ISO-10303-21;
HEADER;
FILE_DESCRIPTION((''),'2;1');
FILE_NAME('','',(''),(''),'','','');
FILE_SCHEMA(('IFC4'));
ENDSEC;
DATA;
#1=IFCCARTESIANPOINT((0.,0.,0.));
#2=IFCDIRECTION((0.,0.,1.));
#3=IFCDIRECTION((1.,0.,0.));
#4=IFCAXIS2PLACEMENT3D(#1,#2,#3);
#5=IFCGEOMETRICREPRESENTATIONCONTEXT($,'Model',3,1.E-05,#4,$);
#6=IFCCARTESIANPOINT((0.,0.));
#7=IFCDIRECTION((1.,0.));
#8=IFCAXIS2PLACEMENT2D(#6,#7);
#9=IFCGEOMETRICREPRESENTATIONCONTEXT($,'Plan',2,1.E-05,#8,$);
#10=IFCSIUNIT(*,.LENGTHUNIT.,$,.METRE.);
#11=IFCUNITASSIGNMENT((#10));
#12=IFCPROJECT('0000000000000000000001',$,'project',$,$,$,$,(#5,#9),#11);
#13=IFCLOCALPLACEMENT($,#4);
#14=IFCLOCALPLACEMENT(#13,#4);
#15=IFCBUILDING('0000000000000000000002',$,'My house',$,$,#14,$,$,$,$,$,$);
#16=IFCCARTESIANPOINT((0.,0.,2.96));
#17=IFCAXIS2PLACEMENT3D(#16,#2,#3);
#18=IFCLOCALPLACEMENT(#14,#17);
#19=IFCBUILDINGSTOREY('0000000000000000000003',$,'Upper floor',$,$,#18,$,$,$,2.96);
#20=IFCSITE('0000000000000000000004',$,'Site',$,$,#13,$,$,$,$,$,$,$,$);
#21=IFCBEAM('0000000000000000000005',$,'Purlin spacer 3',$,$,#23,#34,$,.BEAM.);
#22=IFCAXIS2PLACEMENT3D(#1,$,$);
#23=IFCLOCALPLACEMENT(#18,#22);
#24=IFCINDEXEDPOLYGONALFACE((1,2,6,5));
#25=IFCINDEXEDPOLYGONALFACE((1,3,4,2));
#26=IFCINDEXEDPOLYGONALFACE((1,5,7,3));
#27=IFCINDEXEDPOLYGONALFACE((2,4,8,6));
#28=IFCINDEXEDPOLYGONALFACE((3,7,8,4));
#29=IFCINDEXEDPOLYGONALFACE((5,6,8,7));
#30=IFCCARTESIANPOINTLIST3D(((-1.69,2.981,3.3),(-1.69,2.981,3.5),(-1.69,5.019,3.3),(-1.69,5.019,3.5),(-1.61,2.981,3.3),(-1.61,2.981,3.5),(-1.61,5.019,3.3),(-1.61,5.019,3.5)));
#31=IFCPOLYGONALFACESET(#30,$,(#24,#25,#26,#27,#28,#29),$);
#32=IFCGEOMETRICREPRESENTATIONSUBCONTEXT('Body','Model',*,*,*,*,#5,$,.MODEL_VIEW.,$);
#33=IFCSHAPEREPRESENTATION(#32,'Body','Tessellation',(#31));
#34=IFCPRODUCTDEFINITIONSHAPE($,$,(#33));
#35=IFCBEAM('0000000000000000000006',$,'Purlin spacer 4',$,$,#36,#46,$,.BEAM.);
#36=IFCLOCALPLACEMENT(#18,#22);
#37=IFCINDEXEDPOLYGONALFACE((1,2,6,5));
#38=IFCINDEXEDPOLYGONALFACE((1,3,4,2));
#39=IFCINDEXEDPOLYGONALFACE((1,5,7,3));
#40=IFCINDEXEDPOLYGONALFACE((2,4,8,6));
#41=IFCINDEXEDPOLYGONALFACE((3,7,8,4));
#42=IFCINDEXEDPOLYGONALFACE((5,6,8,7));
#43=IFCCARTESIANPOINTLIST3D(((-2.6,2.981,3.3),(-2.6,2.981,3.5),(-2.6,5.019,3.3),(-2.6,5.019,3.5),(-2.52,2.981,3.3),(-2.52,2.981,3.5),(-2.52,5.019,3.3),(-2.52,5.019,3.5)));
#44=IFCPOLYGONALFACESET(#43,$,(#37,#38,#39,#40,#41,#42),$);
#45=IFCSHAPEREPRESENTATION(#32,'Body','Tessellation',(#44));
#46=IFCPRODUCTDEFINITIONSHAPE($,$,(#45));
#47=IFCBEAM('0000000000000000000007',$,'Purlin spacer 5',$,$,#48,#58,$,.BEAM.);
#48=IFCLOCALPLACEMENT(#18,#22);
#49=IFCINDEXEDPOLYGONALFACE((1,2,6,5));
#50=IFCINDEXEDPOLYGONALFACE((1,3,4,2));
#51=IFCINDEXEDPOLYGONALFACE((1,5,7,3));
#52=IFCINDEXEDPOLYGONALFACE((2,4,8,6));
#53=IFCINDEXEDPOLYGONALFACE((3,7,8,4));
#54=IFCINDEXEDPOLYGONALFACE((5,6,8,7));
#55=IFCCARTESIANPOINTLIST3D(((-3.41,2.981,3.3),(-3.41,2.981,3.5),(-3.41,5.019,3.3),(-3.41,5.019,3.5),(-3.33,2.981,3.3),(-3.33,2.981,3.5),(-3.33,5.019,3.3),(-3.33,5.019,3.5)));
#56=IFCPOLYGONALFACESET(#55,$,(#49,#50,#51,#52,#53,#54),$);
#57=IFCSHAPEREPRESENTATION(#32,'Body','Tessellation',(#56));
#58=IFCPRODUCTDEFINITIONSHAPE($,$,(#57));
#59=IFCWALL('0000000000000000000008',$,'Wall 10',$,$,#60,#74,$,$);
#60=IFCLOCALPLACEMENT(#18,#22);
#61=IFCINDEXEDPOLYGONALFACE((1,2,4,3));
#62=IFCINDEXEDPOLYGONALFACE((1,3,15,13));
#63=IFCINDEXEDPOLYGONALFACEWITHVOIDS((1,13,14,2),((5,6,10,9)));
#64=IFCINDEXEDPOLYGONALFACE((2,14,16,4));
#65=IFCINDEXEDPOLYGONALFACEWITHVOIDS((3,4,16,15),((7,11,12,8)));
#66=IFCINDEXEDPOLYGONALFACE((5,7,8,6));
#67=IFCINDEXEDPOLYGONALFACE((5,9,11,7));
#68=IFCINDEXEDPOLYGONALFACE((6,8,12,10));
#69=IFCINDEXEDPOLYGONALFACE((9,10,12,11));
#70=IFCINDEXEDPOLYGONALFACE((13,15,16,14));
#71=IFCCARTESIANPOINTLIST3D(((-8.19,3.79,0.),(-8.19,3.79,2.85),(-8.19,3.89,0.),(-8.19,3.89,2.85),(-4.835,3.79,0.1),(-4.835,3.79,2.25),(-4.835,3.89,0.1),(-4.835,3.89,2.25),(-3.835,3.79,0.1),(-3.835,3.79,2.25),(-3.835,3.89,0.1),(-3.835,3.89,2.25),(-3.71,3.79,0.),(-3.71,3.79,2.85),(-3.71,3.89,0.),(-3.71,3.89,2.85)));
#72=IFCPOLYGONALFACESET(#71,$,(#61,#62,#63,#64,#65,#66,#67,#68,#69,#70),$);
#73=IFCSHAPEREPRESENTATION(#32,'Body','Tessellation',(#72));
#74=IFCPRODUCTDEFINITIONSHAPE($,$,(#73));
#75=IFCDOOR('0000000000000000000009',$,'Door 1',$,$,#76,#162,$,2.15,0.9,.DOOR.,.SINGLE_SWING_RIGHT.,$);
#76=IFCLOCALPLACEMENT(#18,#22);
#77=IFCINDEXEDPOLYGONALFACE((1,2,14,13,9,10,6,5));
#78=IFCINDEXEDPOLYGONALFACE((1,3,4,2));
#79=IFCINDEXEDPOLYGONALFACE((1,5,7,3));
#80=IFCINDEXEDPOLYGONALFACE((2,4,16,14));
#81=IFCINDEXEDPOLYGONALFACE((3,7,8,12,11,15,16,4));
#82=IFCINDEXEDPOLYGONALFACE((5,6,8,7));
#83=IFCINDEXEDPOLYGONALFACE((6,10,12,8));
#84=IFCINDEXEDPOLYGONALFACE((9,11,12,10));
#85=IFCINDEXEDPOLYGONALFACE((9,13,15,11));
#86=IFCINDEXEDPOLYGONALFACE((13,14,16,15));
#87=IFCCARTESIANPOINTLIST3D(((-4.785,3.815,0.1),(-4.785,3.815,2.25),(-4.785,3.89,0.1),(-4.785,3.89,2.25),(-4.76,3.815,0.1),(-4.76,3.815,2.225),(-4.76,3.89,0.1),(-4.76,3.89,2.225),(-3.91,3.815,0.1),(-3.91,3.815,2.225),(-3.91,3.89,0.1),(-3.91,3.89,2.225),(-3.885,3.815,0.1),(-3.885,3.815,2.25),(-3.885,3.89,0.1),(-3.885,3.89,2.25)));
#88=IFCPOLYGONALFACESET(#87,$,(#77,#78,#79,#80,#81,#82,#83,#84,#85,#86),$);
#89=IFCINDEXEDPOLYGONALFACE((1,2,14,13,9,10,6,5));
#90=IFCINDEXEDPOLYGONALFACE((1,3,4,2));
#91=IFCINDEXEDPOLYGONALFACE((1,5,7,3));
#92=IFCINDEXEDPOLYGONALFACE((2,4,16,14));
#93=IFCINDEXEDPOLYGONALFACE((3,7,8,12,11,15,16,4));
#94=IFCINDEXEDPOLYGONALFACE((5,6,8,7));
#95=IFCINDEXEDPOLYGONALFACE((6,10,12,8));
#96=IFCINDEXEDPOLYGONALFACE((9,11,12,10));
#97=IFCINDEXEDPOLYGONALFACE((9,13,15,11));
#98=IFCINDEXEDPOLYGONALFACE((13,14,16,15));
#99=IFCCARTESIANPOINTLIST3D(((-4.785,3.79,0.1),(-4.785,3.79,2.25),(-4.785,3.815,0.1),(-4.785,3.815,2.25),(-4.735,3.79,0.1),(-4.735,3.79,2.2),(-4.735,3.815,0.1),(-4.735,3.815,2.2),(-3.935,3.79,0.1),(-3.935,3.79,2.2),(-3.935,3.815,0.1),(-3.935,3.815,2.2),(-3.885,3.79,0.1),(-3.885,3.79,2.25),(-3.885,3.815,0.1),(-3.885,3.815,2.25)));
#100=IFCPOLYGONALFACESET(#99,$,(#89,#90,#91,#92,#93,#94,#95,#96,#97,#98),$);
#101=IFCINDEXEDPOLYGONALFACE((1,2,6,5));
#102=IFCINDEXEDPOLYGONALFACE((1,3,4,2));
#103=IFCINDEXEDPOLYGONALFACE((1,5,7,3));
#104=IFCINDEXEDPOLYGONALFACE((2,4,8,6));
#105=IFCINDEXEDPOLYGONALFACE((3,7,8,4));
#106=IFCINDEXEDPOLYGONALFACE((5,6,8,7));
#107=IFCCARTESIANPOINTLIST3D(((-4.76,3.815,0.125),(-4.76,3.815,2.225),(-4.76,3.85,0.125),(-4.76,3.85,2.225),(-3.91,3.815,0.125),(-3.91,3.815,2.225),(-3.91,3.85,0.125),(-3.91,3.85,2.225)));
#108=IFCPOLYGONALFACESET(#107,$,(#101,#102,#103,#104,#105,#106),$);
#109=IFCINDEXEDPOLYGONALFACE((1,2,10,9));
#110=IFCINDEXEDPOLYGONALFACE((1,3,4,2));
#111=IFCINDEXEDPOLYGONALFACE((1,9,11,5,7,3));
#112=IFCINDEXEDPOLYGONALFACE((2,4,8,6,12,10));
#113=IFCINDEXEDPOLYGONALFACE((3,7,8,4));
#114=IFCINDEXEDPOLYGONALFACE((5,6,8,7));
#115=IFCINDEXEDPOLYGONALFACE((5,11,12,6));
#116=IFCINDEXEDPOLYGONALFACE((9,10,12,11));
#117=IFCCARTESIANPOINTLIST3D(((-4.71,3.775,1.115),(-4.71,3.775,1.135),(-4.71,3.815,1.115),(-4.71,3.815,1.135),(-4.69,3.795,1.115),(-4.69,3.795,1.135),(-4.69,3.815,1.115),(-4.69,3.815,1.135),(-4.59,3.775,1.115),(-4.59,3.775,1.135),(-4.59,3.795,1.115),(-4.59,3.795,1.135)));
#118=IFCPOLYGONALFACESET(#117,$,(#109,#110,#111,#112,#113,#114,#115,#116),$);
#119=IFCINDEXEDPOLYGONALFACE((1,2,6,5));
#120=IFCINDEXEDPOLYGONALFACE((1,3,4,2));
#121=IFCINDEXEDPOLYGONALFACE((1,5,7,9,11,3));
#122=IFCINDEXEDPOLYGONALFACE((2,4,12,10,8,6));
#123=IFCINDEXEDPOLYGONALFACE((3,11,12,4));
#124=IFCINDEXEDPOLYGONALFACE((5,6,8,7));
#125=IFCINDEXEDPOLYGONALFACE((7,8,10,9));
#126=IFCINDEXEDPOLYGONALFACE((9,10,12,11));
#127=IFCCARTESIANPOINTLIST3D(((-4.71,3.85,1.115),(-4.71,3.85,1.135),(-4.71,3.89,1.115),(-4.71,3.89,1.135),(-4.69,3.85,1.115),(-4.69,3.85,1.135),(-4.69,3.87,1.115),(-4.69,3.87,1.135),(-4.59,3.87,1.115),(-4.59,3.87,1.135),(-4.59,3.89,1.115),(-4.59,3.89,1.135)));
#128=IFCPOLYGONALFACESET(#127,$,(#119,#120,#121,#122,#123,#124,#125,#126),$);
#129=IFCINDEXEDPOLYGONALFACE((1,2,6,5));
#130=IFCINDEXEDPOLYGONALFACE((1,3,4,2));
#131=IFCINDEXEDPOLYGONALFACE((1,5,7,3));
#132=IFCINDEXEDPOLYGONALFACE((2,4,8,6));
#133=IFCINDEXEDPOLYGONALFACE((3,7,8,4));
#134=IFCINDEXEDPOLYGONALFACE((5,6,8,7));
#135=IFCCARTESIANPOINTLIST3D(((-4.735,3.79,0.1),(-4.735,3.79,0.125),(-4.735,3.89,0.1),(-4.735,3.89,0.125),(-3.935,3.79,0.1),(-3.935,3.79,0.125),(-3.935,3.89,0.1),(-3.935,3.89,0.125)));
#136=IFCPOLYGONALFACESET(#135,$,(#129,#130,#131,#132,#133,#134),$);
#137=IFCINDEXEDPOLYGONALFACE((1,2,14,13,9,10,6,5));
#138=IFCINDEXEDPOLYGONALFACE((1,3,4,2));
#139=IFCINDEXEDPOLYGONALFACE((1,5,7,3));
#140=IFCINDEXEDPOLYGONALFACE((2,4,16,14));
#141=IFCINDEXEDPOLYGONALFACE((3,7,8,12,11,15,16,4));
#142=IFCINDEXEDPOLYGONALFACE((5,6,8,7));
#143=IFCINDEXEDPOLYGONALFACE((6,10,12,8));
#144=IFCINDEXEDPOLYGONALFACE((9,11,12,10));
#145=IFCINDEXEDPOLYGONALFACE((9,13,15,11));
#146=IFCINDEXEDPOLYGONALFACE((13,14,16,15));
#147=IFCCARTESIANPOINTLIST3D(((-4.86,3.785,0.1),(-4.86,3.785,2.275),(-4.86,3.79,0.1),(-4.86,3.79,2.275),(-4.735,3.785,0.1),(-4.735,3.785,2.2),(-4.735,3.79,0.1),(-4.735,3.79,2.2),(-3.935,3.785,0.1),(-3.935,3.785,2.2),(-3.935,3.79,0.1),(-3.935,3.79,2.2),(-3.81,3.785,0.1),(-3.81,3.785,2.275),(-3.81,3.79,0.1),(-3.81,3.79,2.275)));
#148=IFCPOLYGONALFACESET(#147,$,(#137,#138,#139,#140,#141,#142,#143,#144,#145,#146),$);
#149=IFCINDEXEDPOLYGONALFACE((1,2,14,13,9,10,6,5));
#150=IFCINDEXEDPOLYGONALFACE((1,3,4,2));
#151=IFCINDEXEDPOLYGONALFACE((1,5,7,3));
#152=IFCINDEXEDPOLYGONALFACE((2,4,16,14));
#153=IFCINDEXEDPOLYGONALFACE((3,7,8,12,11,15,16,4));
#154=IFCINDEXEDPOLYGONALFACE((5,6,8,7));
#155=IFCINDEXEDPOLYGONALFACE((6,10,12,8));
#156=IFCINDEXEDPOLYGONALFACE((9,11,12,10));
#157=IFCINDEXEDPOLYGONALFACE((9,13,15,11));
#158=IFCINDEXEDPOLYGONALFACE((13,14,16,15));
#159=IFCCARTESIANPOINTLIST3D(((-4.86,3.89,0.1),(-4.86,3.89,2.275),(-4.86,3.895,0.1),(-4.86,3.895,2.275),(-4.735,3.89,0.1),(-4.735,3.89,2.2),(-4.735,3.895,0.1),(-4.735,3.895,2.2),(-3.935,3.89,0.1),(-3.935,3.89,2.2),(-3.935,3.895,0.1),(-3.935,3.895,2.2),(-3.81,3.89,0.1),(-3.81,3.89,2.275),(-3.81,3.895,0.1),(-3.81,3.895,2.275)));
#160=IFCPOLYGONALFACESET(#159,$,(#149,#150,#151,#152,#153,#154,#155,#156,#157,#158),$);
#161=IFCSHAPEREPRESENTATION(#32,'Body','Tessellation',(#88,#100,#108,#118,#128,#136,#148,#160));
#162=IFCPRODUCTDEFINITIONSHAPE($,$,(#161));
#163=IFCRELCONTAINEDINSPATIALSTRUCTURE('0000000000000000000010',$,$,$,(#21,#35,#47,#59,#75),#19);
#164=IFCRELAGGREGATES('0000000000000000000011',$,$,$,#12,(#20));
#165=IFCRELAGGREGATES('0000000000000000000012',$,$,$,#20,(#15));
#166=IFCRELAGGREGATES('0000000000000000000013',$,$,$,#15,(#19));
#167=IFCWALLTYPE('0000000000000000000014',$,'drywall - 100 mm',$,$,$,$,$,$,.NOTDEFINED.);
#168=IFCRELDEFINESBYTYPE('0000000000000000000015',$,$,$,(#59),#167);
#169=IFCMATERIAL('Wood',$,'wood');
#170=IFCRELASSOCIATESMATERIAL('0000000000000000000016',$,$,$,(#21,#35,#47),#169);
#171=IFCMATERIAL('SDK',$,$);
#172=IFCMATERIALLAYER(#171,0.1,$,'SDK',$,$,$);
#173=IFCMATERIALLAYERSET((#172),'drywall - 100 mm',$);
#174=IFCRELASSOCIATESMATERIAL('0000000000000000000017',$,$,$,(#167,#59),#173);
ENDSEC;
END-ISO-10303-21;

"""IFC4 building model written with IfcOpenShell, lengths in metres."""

from ifc_helpers import new_model, entity, si_unit, frame, origin_with_axes, origin_2d_with_axis, place, context, subcontext, project, spatial, line, indexed_curve, rectangle, outline, extrude, shape, source, transform, mapped, material, layer, layer_set, layer_usage, type_object, element, fill, save


model = new_model("IFC4")

# Units and contexts
model_context = context("Model", 3, precision=1e-05, world=origin_with_axes())
plan_context = context("Plan", 2, precision=1e-05, world=origin_2d_with_axis())
body_context_1 = subcontext(model_context, "Body", "Model", "MODEL_VIEW")
body_context_2 = subcontext(plan_context, "Body", "Plan", "PLAN_VIEW")
ifc_project = project(units=[si_unit("LENGTHUNIT", "METRE")], contexts=[model_context, plan_context])

# Site, building, storey
site_placement = place(None, origin_with_axes())
site = spatial("IfcSite", under=ifc_project, at=site_placement, Name="Site")
building_placement = place(site_placement, origin_with_axes())
building = spatial("IfcBuilding", under=site, at=building_placement, Name="My house")
storey_placement = place(building_placement, frame((0.0, 0.0, 2.96), z_axis=(0.0, 0.0, 1.0), x_axis=(1.0, 0.0, 0.0)))
storey = spatial("IfcBuildingStorey", under=building, at=storey_placement, Name="Upper floor", Elevation=2.96)

# Shared definitions
ifc_material_1 = material(Name="Wood", Category="wood")

# Beams
shared_shape_1 = source(origin_with_axes(), body_context_1, "Body", "SweptSolid", [
    extrude(rectangle(XDim=0.08, YDim=0.2), frame((0.0, 0.0, 0.0), z_axis=(1.0, 0.0, 0.0), x_axis=(0.0, 1.0, 0.0)), (0.0, 0.0, 1.0), 2.038),
])
beam_1_placement = place(storey_placement, frame((-1.65, 2.981, 3.4), z_axis=(0.0, 0.0, 1.0), x_axis=(0.0, -1.0, 0.0)))
element("IfcBeam", 1, at=beam_1_placement, inside=storey, material=ifc_material_1, Name="Purlin spacer 3", PredefinedType="BEAM", context=body_context_1, shape_type="MappedRepresentation", body=[
    mapped(shared_shape_1, transform((0.0, 0.0, 0.0), x_axis=(-1.0, 0.0, 0.0), y_axis=(0.0, 1.0, 0.0), z_axis=(0.0, 0.0, 1.0), scale=1.0)),
])
shared_shape_2 = source(origin_with_axes(), body_context_1, "Body", "SweptSolid", [
    extrude(rectangle(XDim=0.08, YDim=0.2), frame((0.0, 0.0, 0.0), z_axis=(1.0, 0.0, 0.0), x_axis=(0.0, 1.0, 0.0)), (0.0, 0.0, 1.0), 2.038),
])
beam_2_placement = place(storey_placement, frame((-2.56, 2.981, 3.4), z_axis=(0.0, 0.0, 1.0), x_axis=(0.0, -1.0, 0.0)))
element("IfcBeam", 2, at=beam_2_placement, inside=storey, material=ifc_material_1, Name="Purlin spacer 4", PredefinedType="BEAM", context=body_context_1, shape_type="MappedRepresentation", body=[
    mapped(shared_shape_2, transform((0.0, 0.0, 0.0), x_axis=(-1.0, 0.0, 0.0), y_axis=(0.0, 1.0, 0.0), z_axis=(0.0, 0.0, 1.0), scale=1.0)),
])
shared_shape_3 = source(origin_with_axes(), body_context_1, "Body", "SweptSolid", [
    extrude(rectangle(XDim=0.08, YDim=0.2), frame((0.0, 0.0, 0.0), z_axis=(1.0, 0.0, 0.0), x_axis=(0.0, 1.0, 0.0)), (0.0, 0.0, 1.0), 2.038),
])
beam_3_placement = place(storey_placement, frame((-3.37, 2.981, 3.4), z_axis=(0.0, 0.0, 1.0), x_axis=(0.0, -1.0, 0.0)))
element("IfcBeam", 3, at=beam_3_placement, inside=storey, material=ifc_material_1, Name="Purlin spacer 5", PredefinedType="BEAM", context=body_context_1, shape_type="MappedRepresentation", body=[
    mapped(shared_shape_3, transform((0.0, 0.0, 0.0), x_axis=(-1.0, 0.0, 0.0), y_axis=(0.0, 1.0, 0.0), z_axis=(0.0, 0.0, 1.0), scale=1.0)),
])

# Wall, opening, door
ifc_material_2 = material(Name="SDK")
ifc_layer_1 = layer(ifc_material_2, 0.1, Name="SDK")
ifc_layer_set_1 = layer_set([ifc_layer_1], Name="drywall - 100 mm")
ifc_layer_usage_1 = layer_usage(ifc_layer_set_1, "AXIS2", "NEGATIVE", 0.1)
wall_type_1 = type_object("IfcWallType", Name="drywall - 100 mm", PredefinedType="NOTDEFINED", material=ifc_layer_set_1)
shared_shape_4 = source(origin_with_axes(), body_context_1, "Body", "SweptSolid", [
    extrude(outline(indexed_curve([(0.0, 0.0), (0.0, 0.1), (4.48, 0.1), (4.48, 0.0), (0.0, 0.0)], self_intersect=False)), origin_with_axes(), (0.0, 0.0, 1.0), 2.85),
])
wall_1_placement = place(storey_placement, frame((-3.71, 3.79, 0.0), z_axis=(0.0, 0.0, 1.0), x_axis=(1.0, 0.0, 0.0)))
wall_1 = element("IfcWall", 4, at=wall_1_placement, inside=storey, type_object=wall_type_1, material=ifc_layer_usage_1, Name="Wall 10", context=body_context_1, shape_type="MappedRepresentation", body=[
    mapped(shared_shape_4, transform((0.0, 0.0, 0.0), x_axis=(-1.0, 0.0, 0.0), y_axis=(0.0, 1.0, 0.0), z_axis=(0.0, 0.0, 1.0), scale=1.0)),
])
shared_shape_5 = source(origin_with_axes(), body_context_1, "Body", "SweptSolid", [
    extrude(outline(indexed_curve([(0.0, 0.0), (0.0, 0.2), (1.0, 0.2), (1.0, 0.0), (0.0, 0.0)], self_intersect=False)), frame((0.0, -0.05, 0.0), z_axis=(0.0, 0.0, 1.0), x_axis=(1.0, 0.0, 0.0)), (0.0, 0.0, 1.0), 2.15),
])
opening_placement = place(wall_1_placement, frame((-0.125, 0.0, 0.1), z_axis=(0.0, 0.0, 1.0), x_axis=(1.0, 0.0, 0.0)))
opening = element("IfcOpeningElement", 5, at=opening_placement, cuts=wall_1, PredefinedType="OPENING", context=body_context_1, shape_type="MappedRepresentation", body=[
    mapped(shared_shape_5, transform((0.0, 0.0, 0.0), x_axis=(-1.0, 0.0, 0.0), y_axis=(0.0, 1.0, 0.0), z_axis=(0.0, 0.0, 1.0), scale=1.0)),
])
shared_indexed_poly_curve = entity("IfcIndexedPolyCurve", entity("IfcCartesianPointList2D", [[-0.075, 0.0], [-0.075, 2.175], [0.975, 2.175], [0.975, 0.0], [0.85, 0.0], [0.85, 2.1], [0.05, 2.1], [0.05, 0.0]]), [entity("IfcLineIndex", [1, 2, 3, 4, 5, 6, 7, 8, 1])])
shared_shape_6 = source(origin_with_axes(), body_context_1, "Body", "SweptSolid", [
    extrude(outline(indexed_curve([(0.0, 0.0), (0.0, 2.15), (0.9, 2.15), (0.9, 0.0), (0.875, 0.0), (0.875, 2.125), (0.025, 2.125), (0.025, 0.0)], segments=[line(1, 2, 3, 4, 5, 6, 7, 8, 1)])), frame((0.0, 0.025, 0.0), z_axis=(0.0, -1.0, 0.0), x_axis=(1.0, 0.0, 0.0)), (0.0, 0.0, -1.0), 0.075),
    extrude(outline(indexed_curve([(0.0, 0.0), (0.0, 2.15), (0.9, 2.15), (0.9, 0.0), (0.85, 0.0), (0.85, 2.1), (0.05, 2.1), (0.05, 0.0)], segments=[line(1, 2, 3, 4, 5, 6, 7, 8, 1)])), frame((0.0, 0.0, 0.0), z_axis=(0.0, -1.0, 0.0), x_axis=(1.0, 0.0, 0.0)), (0.0, 0.0, -1.0), 0.025),
    extrude(outline(indexed_curve([(0.0, 0.0), (0.85, 0.0), (0.85, 0.035), (0.0, 0.035)], segments=[line(1, 2, 3, 4, 1)])), frame((0.025, 0.025, 0.025), z_axis=(0.0, 0.0, 1.0), x_axis=(1.0, 0.0, 0.0)), (0.0, 0.0, 1.0), 2.1),
    extrude(outline(indexed_curve([(0.0, 0.0), (0.0, -0.04), (-0.12, -0.04), (-0.12, -0.02), (-0.02, -0.02), (-0.02, 0.0)], segments=[line(1, 2, 3, 4, 5, 6, 1)])), frame((0.825, 0.025, 1.015), z_axis=(0.0, 0.0, 1.0), x_axis=(1.0, 0.0, 0.0)), (0.0, 0.0, 1.0), 0.02),
    extrude(outline(indexed_curve([(0.0, 0.0), (0.0, 0.04), (-0.12, 0.04), (-0.12, 0.02), (-0.02, 0.02), (-0.02, 0.0)], segments=[line(1, 2, 3, 4, 5, 6, 1)])), frame((0.825, 0.06, 1.015), z_axis=(0.0, 0.0, 1.0), x_axis=(1.0, 0.0, 0.0)), (0.0, 0.0, 1.0), 0.02),
    extrude(outline(indexed_curve([(0.0, 0.0), (0.8, 0.0), (0.8, 0.1), (0.0, 0.1)], segments=[line(1, 2, 3, 4, 1)])), frame((0.05, 0.0, 0.0), z_axis=(0.0, 0.0, 1.0), x_axis=(1.0, 0.0, 0.0)), (0.0, 0.0, 1.0), 0.025),
    entity("IfcExtrudedAreaSolid", entity("IfcArbitraryClosedProfileDef", "AREA", None, shared_indexed_poly_curve), entity("IfcAxis2Placement3D", entity("IfcCartesianPoint", [0.0, -0.005, 0.0]), entity("IfcDirection", [0.0, -1.0, 0.0]), entity("IfcDirection", [1.0, 0.0, 0.0])), entity("IfcDirection", [0.0, 0.0, -1.0]), 0.005),
    entity("IfcExtrudedAreaSolid", entity("IfcArbitraryClosedProfileDef", "AREA", None, shared_indexed_poly_curve), entity("IfcAxis2Placement3D", entity("IfcCartesianPoint", [0.0, 0.1, 0.0]), entity("IfcDirection", [0.0, -1.0, 0.0]), entity("IfcDirection", [1.0, 0.0, 0.0])), entity("IfcDirection", [0.0, 0.0, -1.0]), 0.005),
])
shared_shape_7 = source(origin_with_axes(), body_context_2, "Body", "Curve2D", [
    entity("IfcIndexedPolyCurve", entity("IfcCartesianPointList2D", [[0.0, 0.0], [0.0, 0.1], [0.025, 0.1], [0.025, 0.025], [0.05, 0.025], [0.05, 0.0]]), [entity("IfcLineIndex", [1, 2, 3, 4, 5, 6, 1])]),
    entity("IfcIndexedPolyCurve", entity("IfcCartesianPointList2D", [[0.9, 0.0], [0.9, 0.1], [0.875, 0.1], [0.875, 0.025], [0.85, 0.025], [0.85, 0.0]]), [entity("IfcLineIndex", [1, 2, 3, 4, 5, 6, 1])]),
    entity("IfcTrimmedCurve", entity("IfcEllipse", entity("IfcAxis2Placement2D", entity("IfcCartesianPoint", [0.06, 0.1]), entity("IfcDirection", [1.0, 0.0])), 0.815, 0.85), [entity("IfcCartesianPoint", [0.875, 0.1])], [entity("IfcCartesianPoint", [0.06, 0.95])], True, "CARTESIAN"),
    entity("IfcIndexedPolyCurve", entity("IfcCartesianPointList2D", [[0.025, 0.1], [0.06, 0.1], [0.06, 0.95], [0.025, 0.95]]), [entity("IfcLineIndex", [1, 2, 3, 4, 1])]),
])
door_placement = place(opening_placement, frame((-0.05, 0.0, 0.0), z_axis=(0.0, 0.0, 1.0), x_axis=(1.0, 0.0, 0.0)))
door = element("IfcDoor", 6, at=door_placement, inside=storey, Name="Door 1", OperationType="SINGLE_SWING_RIGHT", OverallHeight=2.15, OverallWidth=0.9, PredefinedType="DOOR", shapes=[
    shape(body_context_1, "Body", "MappedRepresentation", [mapped(shared_shape_6, transform((0.0, 0.0, 0.0), x_axis=(-1.0, 0.0, 0.0), y_axis=(0.0, 1.0, 0.0), z_axis=(0.0, 0.0, 1.0), scale=1.0))]),
    shape(body_context_2, "Body", "MappedRepresentation", [mapped(shared_shape_7, transform((0.0, 0.0, 0.0), x_axis=(-1.0, 0.0, 0.0), y_axis=(0.0, 1.0, 0.0), z_axis=(0.0, 0.0, 1.0), scale=1.0))]),
])
fill(opening, door)

save(model, "model.ifc")
